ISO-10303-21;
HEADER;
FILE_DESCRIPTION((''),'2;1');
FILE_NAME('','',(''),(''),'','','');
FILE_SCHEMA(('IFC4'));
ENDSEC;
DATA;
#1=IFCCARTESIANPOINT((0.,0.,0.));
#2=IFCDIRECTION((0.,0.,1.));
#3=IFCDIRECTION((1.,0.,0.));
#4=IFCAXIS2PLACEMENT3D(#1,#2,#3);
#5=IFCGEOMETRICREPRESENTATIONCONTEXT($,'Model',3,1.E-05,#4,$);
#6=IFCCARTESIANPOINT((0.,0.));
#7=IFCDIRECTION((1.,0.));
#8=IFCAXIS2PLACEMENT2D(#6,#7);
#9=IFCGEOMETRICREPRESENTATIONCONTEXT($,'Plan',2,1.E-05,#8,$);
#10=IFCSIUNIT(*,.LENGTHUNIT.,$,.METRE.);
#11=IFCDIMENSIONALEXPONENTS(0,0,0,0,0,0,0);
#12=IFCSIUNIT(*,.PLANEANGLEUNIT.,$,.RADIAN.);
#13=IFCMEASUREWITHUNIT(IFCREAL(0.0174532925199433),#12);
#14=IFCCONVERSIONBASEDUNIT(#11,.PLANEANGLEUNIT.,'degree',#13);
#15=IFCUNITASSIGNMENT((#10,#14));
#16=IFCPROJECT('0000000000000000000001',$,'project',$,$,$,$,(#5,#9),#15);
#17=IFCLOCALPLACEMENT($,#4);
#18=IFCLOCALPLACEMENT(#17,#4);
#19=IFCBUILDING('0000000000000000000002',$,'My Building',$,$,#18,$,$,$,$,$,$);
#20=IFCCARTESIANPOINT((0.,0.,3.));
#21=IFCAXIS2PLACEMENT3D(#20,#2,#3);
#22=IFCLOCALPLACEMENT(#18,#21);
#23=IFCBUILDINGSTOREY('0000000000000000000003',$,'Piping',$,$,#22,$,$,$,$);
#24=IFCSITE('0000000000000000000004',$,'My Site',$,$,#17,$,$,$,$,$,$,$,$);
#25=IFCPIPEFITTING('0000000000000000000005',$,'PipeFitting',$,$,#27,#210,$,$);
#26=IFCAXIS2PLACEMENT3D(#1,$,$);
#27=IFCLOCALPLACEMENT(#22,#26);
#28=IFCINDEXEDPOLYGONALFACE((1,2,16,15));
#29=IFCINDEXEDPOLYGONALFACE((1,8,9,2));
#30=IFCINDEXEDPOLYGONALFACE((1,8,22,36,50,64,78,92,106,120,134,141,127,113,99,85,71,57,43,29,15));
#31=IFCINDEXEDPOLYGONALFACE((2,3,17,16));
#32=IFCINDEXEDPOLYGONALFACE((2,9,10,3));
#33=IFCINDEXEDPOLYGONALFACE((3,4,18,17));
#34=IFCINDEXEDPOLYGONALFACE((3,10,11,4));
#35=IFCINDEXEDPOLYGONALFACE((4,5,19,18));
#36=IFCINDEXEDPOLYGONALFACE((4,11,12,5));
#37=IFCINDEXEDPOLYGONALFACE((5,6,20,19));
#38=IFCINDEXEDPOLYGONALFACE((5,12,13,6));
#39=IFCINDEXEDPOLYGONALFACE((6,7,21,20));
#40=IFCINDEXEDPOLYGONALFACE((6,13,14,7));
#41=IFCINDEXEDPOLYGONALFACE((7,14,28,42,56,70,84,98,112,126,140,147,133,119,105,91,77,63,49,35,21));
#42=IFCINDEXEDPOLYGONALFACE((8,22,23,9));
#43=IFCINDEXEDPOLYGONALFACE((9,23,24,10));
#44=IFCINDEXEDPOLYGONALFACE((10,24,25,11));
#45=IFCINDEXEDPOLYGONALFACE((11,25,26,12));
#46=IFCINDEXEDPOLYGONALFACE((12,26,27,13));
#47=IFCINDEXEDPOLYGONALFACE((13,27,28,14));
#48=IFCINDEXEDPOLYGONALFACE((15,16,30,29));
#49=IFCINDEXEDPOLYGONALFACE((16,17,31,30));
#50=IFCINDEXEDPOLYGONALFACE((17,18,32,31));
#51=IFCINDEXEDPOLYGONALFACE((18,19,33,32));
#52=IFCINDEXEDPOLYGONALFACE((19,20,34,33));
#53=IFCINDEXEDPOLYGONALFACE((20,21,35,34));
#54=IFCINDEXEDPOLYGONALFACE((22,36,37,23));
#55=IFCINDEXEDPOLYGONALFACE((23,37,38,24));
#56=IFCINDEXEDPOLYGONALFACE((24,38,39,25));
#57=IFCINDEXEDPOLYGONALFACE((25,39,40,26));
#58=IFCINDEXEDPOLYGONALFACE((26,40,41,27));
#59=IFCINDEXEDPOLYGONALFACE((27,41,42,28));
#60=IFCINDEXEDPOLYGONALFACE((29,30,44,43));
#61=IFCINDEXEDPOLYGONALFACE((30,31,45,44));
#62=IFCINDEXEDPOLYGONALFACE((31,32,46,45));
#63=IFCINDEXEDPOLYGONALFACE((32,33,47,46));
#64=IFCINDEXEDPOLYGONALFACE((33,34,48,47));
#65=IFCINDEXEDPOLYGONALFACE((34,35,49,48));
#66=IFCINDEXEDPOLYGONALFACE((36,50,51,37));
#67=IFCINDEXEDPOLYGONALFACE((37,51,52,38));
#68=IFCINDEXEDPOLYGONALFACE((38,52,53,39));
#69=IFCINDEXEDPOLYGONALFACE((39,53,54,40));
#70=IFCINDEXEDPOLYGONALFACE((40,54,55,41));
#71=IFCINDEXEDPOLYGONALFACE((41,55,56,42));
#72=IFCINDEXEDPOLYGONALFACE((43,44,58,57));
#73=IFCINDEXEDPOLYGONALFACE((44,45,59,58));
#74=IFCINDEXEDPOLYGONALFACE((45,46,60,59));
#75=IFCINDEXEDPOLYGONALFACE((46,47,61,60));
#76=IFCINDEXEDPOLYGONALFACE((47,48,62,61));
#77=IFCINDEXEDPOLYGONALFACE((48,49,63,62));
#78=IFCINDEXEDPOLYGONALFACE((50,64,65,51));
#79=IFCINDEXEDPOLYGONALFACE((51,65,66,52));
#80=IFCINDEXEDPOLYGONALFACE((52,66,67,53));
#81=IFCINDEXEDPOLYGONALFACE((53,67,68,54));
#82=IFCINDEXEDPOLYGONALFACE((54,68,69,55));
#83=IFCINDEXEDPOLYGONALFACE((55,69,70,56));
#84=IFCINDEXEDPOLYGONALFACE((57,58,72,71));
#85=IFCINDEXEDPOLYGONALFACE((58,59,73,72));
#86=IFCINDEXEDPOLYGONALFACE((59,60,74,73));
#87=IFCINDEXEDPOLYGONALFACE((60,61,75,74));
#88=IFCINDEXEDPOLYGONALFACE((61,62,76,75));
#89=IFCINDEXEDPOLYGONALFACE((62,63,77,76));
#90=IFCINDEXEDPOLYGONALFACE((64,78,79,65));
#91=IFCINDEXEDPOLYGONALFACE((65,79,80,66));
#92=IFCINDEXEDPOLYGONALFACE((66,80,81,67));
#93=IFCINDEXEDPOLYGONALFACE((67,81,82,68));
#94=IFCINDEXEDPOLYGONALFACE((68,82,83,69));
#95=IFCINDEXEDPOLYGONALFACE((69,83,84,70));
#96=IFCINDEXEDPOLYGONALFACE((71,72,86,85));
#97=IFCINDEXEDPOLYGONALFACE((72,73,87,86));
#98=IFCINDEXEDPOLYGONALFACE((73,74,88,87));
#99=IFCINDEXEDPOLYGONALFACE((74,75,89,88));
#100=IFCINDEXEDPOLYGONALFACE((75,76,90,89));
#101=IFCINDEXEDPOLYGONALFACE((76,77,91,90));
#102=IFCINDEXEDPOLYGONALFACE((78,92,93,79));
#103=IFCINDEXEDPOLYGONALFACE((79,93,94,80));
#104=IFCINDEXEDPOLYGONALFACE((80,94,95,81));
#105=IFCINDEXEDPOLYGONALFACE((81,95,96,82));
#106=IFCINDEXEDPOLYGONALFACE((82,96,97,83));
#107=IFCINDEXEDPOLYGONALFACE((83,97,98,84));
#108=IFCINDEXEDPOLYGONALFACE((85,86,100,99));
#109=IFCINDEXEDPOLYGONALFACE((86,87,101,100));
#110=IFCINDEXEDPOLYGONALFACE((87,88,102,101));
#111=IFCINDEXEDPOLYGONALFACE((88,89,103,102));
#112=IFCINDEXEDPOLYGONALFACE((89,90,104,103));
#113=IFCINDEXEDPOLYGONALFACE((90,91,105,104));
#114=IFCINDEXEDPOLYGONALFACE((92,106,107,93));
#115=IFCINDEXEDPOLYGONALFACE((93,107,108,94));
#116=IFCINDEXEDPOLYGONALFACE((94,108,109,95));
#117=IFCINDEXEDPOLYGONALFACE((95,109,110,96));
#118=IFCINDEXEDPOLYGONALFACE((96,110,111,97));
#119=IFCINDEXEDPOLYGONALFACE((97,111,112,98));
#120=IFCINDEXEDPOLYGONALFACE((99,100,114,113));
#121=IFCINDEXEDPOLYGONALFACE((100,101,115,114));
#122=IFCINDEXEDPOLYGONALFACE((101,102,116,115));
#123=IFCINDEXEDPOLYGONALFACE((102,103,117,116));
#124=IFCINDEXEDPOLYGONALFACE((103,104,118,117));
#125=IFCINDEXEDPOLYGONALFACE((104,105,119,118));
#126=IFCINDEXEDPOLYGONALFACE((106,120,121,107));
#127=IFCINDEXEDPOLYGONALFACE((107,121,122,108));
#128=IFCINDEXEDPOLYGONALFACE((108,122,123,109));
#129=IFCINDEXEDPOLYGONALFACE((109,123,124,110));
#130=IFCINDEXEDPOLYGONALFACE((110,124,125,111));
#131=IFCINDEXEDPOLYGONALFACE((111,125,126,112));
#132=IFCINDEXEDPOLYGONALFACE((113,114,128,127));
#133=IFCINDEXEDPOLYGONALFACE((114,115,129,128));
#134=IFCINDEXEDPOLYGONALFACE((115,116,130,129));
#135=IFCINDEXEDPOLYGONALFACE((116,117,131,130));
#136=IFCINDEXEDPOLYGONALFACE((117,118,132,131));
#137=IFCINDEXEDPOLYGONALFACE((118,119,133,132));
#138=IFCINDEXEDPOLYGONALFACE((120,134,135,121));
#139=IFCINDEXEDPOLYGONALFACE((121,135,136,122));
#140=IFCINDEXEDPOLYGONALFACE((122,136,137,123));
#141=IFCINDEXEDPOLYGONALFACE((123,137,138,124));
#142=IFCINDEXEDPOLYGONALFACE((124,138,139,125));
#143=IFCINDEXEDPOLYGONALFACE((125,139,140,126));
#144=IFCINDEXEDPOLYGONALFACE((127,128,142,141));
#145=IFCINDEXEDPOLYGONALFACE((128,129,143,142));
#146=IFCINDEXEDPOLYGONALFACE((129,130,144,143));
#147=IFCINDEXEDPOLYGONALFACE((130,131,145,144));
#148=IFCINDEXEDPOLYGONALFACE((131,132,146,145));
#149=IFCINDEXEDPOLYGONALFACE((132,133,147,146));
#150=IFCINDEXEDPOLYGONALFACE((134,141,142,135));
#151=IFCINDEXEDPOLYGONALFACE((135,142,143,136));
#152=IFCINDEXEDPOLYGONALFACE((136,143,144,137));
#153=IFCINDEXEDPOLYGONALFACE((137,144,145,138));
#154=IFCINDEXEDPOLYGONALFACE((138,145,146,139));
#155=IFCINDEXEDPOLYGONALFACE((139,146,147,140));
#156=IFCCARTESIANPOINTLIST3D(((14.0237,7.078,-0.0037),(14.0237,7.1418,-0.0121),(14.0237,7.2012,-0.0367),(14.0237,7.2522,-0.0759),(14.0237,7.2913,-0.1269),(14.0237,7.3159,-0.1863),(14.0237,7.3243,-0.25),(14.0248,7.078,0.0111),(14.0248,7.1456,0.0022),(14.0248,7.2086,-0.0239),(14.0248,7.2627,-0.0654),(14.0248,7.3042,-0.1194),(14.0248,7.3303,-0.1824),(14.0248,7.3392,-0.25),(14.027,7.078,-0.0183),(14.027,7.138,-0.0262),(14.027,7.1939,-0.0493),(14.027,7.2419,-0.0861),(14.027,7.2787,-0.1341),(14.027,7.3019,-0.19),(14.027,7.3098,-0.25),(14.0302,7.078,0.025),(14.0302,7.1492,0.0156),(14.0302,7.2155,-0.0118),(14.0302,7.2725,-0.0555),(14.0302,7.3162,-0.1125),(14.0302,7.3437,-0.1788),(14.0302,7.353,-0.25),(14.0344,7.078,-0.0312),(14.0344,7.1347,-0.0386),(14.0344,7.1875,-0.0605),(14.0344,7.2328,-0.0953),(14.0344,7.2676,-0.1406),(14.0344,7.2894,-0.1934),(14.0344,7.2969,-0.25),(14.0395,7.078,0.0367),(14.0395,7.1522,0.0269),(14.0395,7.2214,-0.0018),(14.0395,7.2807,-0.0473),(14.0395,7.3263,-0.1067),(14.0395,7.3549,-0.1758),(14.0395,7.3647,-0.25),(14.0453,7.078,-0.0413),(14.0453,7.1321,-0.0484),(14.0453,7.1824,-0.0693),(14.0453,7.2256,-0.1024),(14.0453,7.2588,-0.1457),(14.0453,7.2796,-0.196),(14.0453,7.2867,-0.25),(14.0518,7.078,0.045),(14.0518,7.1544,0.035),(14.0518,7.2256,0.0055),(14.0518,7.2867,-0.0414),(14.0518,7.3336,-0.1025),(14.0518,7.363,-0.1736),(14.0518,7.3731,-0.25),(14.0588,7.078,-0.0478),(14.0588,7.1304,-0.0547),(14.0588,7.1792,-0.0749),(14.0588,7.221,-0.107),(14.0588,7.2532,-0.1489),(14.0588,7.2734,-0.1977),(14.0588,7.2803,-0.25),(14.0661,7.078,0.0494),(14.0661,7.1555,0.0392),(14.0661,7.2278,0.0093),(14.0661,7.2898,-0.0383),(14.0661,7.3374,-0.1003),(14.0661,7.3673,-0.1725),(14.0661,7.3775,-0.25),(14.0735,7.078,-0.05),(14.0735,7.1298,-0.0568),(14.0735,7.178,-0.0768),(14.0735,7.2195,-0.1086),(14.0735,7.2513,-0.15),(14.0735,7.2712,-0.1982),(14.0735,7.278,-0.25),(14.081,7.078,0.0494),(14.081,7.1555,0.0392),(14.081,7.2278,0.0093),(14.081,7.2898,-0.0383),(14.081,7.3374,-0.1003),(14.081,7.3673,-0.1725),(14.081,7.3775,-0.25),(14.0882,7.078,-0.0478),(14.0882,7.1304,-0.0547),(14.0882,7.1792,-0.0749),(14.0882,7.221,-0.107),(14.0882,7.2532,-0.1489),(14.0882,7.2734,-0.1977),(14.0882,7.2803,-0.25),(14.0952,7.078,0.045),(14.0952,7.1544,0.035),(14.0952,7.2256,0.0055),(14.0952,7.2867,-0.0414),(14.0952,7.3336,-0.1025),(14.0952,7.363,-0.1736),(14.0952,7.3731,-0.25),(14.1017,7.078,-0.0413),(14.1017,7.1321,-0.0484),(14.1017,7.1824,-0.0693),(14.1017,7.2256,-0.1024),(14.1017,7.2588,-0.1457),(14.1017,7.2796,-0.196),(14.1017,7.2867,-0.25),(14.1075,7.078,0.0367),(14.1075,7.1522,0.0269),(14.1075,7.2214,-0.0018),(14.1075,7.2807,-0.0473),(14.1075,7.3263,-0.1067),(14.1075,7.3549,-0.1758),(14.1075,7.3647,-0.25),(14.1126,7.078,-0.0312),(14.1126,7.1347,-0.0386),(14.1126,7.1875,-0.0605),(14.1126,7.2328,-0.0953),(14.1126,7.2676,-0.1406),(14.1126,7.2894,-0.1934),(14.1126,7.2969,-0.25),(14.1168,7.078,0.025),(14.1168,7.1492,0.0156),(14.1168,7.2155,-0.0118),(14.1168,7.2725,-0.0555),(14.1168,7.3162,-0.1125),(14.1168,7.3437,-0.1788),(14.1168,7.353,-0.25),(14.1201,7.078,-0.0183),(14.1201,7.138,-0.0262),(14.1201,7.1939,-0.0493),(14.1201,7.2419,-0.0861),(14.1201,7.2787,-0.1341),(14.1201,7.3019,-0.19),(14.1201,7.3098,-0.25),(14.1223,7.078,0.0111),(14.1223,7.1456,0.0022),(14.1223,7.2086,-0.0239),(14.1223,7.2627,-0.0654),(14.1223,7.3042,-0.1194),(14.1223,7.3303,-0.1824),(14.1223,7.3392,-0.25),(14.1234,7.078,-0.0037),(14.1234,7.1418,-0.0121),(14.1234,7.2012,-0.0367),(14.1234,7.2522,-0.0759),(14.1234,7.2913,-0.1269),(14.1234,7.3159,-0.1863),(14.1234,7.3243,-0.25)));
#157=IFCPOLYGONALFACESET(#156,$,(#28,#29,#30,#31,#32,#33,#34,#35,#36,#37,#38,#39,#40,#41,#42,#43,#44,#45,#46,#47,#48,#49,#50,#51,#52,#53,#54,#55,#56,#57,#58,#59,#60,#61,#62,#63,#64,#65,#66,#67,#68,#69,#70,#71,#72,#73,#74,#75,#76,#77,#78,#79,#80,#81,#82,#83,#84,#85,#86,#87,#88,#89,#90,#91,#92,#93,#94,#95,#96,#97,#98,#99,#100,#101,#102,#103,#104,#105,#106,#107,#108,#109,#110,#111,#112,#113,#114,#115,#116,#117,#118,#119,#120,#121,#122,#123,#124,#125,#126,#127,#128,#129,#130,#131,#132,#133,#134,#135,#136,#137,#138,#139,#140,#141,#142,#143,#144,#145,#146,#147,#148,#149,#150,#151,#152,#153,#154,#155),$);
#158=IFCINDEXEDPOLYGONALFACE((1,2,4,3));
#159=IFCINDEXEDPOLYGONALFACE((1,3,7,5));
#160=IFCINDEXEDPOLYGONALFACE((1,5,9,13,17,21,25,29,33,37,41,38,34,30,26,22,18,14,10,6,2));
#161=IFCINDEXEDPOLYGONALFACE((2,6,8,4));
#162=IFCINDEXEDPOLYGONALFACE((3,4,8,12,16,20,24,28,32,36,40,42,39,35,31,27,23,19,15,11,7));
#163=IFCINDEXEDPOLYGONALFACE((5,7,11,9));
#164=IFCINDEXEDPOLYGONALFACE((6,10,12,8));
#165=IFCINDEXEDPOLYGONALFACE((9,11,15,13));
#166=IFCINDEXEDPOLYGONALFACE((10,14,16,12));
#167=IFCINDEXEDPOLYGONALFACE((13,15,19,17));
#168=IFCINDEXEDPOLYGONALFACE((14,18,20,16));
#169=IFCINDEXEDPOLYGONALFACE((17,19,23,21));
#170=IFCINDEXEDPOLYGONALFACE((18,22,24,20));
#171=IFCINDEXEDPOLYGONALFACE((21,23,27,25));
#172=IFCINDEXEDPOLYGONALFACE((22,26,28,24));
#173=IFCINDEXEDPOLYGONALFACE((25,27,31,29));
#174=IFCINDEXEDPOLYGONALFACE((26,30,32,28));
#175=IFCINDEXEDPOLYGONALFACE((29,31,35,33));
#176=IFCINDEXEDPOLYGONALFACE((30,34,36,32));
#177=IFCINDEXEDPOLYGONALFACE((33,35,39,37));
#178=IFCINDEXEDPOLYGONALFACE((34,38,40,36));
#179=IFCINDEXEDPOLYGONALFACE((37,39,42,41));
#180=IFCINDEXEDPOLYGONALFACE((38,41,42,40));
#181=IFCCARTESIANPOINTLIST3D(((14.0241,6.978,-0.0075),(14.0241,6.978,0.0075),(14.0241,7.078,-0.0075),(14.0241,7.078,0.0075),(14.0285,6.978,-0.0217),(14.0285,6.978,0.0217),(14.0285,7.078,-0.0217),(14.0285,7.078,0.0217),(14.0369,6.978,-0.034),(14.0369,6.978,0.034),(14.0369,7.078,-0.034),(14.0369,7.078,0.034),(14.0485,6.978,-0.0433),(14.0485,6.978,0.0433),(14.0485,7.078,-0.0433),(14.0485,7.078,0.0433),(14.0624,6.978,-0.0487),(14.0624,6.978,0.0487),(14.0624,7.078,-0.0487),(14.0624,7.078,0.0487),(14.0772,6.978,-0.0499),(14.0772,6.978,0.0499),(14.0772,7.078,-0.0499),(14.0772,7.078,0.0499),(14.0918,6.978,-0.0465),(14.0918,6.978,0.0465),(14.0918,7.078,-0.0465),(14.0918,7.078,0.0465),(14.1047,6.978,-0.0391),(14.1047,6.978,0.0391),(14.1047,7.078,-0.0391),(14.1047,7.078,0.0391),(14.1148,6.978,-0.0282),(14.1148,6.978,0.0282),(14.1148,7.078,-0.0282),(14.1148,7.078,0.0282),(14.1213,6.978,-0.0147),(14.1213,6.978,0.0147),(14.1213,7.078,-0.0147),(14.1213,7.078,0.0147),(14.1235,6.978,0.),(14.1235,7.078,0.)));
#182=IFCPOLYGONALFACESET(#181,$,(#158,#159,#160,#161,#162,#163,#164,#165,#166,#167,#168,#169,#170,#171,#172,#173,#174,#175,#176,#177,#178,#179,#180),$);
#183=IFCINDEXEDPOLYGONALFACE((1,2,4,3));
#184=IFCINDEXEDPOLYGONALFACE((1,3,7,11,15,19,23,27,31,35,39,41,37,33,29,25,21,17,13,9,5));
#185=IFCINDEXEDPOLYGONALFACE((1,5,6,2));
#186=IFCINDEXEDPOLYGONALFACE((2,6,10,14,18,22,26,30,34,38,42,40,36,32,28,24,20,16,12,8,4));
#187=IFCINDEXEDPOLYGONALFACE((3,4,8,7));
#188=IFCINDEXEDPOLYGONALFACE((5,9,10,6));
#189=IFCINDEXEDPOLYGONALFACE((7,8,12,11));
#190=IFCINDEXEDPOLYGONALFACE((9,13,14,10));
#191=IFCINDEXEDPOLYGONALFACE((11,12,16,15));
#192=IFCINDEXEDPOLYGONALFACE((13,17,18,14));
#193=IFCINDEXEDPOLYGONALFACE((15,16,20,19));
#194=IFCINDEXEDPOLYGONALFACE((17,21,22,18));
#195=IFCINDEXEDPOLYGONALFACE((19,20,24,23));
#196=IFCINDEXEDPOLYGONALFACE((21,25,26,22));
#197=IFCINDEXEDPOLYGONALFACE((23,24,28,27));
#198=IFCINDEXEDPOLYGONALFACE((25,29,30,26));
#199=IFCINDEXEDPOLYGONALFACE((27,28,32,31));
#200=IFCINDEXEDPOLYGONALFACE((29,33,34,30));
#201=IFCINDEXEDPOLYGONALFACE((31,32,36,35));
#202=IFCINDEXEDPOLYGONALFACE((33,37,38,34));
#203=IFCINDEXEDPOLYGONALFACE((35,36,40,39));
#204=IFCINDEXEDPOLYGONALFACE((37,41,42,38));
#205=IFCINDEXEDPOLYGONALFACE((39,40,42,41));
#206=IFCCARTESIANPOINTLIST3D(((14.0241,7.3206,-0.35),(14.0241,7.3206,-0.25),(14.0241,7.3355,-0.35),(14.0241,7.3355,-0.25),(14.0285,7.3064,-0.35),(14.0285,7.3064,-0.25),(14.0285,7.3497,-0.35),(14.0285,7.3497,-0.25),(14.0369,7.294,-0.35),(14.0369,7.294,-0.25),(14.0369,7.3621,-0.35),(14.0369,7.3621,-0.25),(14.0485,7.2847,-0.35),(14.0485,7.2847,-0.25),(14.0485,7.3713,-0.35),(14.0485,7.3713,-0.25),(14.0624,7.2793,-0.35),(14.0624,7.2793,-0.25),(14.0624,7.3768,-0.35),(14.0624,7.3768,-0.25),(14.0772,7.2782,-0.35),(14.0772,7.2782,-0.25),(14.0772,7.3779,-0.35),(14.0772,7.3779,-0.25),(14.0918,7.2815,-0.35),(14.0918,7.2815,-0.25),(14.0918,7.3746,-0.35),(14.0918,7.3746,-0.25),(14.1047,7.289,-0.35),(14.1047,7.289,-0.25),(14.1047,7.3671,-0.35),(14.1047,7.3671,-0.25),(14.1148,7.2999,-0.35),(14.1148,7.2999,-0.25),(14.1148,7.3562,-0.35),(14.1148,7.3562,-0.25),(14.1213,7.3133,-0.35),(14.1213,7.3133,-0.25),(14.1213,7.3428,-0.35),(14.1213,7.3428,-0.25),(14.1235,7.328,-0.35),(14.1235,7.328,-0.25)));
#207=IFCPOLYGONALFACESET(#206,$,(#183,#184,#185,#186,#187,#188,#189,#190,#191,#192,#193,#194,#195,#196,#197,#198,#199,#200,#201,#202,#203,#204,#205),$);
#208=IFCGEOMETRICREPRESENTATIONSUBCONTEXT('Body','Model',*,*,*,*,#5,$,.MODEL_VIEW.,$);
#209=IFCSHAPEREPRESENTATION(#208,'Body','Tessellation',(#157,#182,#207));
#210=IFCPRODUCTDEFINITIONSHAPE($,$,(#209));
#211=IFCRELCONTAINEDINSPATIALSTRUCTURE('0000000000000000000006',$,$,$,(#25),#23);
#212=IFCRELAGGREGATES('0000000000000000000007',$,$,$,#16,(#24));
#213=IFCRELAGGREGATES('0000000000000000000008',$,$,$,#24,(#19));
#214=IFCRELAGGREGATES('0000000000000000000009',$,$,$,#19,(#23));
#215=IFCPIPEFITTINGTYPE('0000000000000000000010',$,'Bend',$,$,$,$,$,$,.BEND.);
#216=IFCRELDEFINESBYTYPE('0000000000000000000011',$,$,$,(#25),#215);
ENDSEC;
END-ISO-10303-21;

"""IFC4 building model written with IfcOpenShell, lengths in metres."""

from ifc_helpers import new_model, entity, si_unit, converted_unit, frame, origin_with_axes, origin_2d_with_axis, place, context, subcontext, project, spatial, circle, extrude, source, transform, mapped, type_object, type_shapes, element, save


model = new_model("IFC4")

# Units and contexts
model_context = context("Model", 3, precision=1e-05, world=origin_with_axes())
plan_context = context("Plan", 2, precision=1e-05, world=origin_2d_with_axis())
body_context = subcontext(model_context, "Body", "Model", "MODEL_VIEW")
ifc_project = project(units=[si_unit("LENGTHUNIT", "METRE"), converted_unit("PLANEANGLEUNIT", "degree", entity("IfcReal", 0.0174532925199433), si_unit("PLANEANGLEUNIT", "RADIAN"), dimensions=[0, 0, 0, 0, 0, 0, 0])], contexts=[model_context, plan_context])

# Site, building, storey
site_placement = place(None, origin_with_axes())
site = spatial("IfcSite", under=ifc_project, at=site_placement, Name="My Site")
building_placement = place(site_placement, origin_with_axes())
building = spatial("IfcBuilding", under=site, at=building_placement, Name="My Building")
storey_placement = place(building_placement, frame((0.0, 0.0, 3.0), z_axis=(0.0, 0.0, 1.0), x_axis=(1.0, 0.0, 0.0)))
storey = spatial("IfcBuildingStorey", under=building, at=storey_placement, Name="Piping")

# Pipe fitting
pipe_fitting_type_1 = type_object("IfcPipeFittingType", Name="Bend", PredefinedType="BEND")
shared_shape = source(origin_with_axes(), body_context, "Body", "SolidModel", [
    entity("IfcSweptDiskSolid", entity("IfcIndexedPolyCurve", entity("IfcCartesianPointList3D", [[0.0, 0.0, -0.1], [0.0, -0.0732, -0.2768], [0.0, -0.25, -0.35]]), [entity("IfcArcIndex", [1, 2, 3])]), 0.05),
    extrude(circle(Radius=0.05), origin_with_axes(), (0.0, 0.0, -1.0), 0.1),
    extrude(circle(Radius=0.05), frame((0.0, -0.25, -0.35), z_axis=(0.0, -1.0, 0.0), x_axis=(1.0, 0.0, 0.0)), (0.0, 0.0, 1.0), 0.1),
])
type_shapes(pipe_fitting_type_1, [shared_shape])
for number, where, z_axis, x_axis, name in (
    (1, (14.0735, 6.978, 0.0), (0.0, -1.0, 0.0), (1.0, 0.0, 0.0), "PipeFitting"),
):
    element("IfcPipeFitting", number, at=place(storey_placement, frame(where, z_axis=z_axis, x_axis=x_axis)), inside=storey, type_object=pipe_fitting_type_1, Name=name, context=body_context, shape_type="MappedRepresentation", body=[
        mapped(shared_shape, transform((0.0, 0.0, 0.0), x_axis=(1.0, 0.0, 0.0), y_axis=(0.0, 1.0, 0.0), z_axis=(0.0, 0.0, 1.0), scale=1.0)),
    ])

save(model, "model.ifc")
